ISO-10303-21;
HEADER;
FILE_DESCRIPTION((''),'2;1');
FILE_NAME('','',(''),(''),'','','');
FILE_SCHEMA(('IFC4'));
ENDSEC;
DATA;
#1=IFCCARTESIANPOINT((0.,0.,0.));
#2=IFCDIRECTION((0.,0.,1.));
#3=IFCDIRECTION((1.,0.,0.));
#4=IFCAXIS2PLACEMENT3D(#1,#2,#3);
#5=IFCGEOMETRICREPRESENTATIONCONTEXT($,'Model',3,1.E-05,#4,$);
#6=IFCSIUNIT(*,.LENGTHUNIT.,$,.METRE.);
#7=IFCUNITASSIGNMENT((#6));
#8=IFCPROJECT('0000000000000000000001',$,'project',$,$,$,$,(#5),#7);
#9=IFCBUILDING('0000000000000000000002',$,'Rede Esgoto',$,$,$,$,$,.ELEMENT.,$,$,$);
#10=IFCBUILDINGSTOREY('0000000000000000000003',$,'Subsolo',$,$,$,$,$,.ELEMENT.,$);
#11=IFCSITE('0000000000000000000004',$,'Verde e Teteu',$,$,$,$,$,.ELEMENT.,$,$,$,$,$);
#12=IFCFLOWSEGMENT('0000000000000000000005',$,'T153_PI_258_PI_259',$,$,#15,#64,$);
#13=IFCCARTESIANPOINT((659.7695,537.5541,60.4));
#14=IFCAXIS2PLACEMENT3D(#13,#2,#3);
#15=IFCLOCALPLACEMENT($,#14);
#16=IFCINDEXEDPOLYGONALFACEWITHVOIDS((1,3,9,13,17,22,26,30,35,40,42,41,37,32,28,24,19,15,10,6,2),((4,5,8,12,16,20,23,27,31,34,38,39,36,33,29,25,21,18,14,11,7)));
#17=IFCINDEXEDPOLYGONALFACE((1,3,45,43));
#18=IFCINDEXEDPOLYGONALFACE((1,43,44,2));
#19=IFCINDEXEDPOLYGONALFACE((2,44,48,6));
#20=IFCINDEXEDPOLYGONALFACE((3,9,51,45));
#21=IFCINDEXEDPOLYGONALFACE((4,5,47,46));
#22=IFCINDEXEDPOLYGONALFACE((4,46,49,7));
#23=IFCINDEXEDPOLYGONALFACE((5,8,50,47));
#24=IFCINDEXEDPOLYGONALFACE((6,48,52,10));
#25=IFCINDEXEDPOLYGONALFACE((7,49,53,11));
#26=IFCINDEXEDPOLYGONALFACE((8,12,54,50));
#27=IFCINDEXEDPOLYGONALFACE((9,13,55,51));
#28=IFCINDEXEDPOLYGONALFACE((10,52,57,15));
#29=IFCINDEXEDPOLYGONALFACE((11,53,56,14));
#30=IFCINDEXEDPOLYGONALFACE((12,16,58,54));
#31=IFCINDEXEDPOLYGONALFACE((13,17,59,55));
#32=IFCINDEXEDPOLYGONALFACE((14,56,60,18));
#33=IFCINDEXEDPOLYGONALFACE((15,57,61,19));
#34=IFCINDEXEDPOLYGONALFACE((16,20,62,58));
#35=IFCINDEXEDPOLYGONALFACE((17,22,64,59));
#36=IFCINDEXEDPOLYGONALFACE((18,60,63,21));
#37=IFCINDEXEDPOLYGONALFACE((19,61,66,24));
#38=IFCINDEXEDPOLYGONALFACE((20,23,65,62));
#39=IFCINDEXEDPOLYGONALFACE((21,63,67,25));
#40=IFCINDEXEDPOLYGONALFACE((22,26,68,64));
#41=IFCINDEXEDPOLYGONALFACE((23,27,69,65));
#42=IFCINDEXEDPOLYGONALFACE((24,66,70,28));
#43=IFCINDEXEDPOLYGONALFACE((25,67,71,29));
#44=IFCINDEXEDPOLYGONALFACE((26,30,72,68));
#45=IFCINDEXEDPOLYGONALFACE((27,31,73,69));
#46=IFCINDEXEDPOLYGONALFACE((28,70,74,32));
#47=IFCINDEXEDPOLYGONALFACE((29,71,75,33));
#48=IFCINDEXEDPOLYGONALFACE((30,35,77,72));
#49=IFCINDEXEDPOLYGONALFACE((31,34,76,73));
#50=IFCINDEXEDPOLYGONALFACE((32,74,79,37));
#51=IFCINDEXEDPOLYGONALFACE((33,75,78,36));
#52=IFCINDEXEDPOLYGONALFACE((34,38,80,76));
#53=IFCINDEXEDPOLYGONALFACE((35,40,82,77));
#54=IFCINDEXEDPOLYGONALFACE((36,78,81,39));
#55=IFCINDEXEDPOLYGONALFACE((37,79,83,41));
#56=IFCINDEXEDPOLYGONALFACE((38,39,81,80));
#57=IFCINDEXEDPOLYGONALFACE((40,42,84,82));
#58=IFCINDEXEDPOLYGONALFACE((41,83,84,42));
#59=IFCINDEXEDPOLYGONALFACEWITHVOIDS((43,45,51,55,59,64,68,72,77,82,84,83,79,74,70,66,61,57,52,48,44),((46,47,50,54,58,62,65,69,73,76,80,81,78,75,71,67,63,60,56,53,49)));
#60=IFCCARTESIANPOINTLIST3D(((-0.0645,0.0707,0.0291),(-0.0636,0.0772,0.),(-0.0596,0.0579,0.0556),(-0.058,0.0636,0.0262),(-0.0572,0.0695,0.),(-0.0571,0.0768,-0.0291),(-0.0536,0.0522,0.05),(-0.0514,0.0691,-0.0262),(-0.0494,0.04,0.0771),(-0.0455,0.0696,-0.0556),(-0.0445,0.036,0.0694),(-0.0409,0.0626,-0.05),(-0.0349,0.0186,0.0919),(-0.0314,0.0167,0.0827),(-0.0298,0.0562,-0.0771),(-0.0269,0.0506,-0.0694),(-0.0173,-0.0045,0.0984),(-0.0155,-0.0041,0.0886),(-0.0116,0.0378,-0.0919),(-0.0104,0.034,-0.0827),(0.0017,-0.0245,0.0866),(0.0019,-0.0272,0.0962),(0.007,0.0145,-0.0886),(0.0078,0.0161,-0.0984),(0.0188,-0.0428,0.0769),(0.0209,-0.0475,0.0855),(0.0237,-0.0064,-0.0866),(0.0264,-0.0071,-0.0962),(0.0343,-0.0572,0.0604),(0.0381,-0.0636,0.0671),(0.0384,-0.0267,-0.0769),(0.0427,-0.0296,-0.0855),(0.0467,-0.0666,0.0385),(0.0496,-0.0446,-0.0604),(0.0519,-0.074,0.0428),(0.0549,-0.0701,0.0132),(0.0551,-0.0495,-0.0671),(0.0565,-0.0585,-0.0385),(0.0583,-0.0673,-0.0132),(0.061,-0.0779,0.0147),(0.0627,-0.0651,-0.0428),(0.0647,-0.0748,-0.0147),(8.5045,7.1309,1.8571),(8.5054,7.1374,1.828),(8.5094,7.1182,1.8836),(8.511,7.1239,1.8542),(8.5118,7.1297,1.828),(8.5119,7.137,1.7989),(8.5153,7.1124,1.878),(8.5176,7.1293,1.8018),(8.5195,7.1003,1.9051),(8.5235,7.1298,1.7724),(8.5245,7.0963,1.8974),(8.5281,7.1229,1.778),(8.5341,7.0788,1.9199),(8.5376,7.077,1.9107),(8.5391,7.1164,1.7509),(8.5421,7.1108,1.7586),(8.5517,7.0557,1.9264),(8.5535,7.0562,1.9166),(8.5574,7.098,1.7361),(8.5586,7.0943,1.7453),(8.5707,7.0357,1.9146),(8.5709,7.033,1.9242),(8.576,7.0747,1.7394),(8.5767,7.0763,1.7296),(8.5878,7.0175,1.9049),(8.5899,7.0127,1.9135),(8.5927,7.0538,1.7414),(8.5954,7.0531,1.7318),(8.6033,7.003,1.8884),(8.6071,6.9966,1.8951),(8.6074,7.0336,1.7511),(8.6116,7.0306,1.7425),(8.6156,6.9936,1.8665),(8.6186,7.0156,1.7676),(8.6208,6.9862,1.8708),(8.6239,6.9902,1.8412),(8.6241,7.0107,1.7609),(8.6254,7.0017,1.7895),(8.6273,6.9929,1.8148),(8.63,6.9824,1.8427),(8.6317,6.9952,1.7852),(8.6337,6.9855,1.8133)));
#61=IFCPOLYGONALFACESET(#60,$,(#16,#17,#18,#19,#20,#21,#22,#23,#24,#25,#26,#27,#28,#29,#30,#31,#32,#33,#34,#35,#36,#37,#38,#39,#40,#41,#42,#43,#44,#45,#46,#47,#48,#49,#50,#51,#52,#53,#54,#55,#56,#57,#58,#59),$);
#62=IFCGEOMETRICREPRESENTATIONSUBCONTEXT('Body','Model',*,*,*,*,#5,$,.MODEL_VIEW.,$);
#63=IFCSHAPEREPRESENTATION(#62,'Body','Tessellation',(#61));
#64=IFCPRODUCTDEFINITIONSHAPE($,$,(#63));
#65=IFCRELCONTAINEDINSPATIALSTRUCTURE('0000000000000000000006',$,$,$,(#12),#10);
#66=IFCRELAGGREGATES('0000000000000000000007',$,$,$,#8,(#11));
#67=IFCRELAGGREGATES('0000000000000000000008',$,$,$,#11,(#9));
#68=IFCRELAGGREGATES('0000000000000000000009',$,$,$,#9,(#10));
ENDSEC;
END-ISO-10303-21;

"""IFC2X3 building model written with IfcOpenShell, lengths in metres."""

from ifc_helpers import new_model, entity, si_unit, frame, origin_with_axes, place, context, subcontext, project, spatial, element, save


model = new_model("IFC2X3")

# Units and contexts
model_context = context("Model", 3, precision=1e-05, world=origin_with_axes())
body_context = subcontext(model_context, "Body", "Model", "MODEL_VIEW")
ifc_project = project(units=[si_unit("LENGTHUNIT", "METRE")], contexts=[model_context])

# Site, building, storey
site = spatial("IfcSite", under=ifc_project, Name="Verde e Teteu", CompositionType="ELEMENT")
building = spatial("IfcBuilding", under=site, Name="Rede Esgoto", CompositionType="ELEMENT")
storey = spatial("IfcBuildingStorey", under=building, Name="Subsolo", CompositionType="ELEMENT")

# Flow segment
flow_segment_1_placement = place(None, frame((659.7695, 537.5541, 60.4), z_axis=(0.0, 0.0, 1.0), x_axis=(1.0, 0.0, 0.0)))
element("IfcFlowSegment", 1, at=flow_segment_1_placement, inside=storey, Name="T153_PI_258_PI_259", context=body_context, shape_type="SweptSolid", body=[
    entity("IfcSweptDiskSolid", entity("IfcPolyline", [entity("IfcCartesianPoint", [0.0, 0.0, 0.0]), entity("IfcCartesianPoint", [8.569, 7.0602, 1.828])]), 0.1, 0.09),
])

save(model, "model.ifc")
